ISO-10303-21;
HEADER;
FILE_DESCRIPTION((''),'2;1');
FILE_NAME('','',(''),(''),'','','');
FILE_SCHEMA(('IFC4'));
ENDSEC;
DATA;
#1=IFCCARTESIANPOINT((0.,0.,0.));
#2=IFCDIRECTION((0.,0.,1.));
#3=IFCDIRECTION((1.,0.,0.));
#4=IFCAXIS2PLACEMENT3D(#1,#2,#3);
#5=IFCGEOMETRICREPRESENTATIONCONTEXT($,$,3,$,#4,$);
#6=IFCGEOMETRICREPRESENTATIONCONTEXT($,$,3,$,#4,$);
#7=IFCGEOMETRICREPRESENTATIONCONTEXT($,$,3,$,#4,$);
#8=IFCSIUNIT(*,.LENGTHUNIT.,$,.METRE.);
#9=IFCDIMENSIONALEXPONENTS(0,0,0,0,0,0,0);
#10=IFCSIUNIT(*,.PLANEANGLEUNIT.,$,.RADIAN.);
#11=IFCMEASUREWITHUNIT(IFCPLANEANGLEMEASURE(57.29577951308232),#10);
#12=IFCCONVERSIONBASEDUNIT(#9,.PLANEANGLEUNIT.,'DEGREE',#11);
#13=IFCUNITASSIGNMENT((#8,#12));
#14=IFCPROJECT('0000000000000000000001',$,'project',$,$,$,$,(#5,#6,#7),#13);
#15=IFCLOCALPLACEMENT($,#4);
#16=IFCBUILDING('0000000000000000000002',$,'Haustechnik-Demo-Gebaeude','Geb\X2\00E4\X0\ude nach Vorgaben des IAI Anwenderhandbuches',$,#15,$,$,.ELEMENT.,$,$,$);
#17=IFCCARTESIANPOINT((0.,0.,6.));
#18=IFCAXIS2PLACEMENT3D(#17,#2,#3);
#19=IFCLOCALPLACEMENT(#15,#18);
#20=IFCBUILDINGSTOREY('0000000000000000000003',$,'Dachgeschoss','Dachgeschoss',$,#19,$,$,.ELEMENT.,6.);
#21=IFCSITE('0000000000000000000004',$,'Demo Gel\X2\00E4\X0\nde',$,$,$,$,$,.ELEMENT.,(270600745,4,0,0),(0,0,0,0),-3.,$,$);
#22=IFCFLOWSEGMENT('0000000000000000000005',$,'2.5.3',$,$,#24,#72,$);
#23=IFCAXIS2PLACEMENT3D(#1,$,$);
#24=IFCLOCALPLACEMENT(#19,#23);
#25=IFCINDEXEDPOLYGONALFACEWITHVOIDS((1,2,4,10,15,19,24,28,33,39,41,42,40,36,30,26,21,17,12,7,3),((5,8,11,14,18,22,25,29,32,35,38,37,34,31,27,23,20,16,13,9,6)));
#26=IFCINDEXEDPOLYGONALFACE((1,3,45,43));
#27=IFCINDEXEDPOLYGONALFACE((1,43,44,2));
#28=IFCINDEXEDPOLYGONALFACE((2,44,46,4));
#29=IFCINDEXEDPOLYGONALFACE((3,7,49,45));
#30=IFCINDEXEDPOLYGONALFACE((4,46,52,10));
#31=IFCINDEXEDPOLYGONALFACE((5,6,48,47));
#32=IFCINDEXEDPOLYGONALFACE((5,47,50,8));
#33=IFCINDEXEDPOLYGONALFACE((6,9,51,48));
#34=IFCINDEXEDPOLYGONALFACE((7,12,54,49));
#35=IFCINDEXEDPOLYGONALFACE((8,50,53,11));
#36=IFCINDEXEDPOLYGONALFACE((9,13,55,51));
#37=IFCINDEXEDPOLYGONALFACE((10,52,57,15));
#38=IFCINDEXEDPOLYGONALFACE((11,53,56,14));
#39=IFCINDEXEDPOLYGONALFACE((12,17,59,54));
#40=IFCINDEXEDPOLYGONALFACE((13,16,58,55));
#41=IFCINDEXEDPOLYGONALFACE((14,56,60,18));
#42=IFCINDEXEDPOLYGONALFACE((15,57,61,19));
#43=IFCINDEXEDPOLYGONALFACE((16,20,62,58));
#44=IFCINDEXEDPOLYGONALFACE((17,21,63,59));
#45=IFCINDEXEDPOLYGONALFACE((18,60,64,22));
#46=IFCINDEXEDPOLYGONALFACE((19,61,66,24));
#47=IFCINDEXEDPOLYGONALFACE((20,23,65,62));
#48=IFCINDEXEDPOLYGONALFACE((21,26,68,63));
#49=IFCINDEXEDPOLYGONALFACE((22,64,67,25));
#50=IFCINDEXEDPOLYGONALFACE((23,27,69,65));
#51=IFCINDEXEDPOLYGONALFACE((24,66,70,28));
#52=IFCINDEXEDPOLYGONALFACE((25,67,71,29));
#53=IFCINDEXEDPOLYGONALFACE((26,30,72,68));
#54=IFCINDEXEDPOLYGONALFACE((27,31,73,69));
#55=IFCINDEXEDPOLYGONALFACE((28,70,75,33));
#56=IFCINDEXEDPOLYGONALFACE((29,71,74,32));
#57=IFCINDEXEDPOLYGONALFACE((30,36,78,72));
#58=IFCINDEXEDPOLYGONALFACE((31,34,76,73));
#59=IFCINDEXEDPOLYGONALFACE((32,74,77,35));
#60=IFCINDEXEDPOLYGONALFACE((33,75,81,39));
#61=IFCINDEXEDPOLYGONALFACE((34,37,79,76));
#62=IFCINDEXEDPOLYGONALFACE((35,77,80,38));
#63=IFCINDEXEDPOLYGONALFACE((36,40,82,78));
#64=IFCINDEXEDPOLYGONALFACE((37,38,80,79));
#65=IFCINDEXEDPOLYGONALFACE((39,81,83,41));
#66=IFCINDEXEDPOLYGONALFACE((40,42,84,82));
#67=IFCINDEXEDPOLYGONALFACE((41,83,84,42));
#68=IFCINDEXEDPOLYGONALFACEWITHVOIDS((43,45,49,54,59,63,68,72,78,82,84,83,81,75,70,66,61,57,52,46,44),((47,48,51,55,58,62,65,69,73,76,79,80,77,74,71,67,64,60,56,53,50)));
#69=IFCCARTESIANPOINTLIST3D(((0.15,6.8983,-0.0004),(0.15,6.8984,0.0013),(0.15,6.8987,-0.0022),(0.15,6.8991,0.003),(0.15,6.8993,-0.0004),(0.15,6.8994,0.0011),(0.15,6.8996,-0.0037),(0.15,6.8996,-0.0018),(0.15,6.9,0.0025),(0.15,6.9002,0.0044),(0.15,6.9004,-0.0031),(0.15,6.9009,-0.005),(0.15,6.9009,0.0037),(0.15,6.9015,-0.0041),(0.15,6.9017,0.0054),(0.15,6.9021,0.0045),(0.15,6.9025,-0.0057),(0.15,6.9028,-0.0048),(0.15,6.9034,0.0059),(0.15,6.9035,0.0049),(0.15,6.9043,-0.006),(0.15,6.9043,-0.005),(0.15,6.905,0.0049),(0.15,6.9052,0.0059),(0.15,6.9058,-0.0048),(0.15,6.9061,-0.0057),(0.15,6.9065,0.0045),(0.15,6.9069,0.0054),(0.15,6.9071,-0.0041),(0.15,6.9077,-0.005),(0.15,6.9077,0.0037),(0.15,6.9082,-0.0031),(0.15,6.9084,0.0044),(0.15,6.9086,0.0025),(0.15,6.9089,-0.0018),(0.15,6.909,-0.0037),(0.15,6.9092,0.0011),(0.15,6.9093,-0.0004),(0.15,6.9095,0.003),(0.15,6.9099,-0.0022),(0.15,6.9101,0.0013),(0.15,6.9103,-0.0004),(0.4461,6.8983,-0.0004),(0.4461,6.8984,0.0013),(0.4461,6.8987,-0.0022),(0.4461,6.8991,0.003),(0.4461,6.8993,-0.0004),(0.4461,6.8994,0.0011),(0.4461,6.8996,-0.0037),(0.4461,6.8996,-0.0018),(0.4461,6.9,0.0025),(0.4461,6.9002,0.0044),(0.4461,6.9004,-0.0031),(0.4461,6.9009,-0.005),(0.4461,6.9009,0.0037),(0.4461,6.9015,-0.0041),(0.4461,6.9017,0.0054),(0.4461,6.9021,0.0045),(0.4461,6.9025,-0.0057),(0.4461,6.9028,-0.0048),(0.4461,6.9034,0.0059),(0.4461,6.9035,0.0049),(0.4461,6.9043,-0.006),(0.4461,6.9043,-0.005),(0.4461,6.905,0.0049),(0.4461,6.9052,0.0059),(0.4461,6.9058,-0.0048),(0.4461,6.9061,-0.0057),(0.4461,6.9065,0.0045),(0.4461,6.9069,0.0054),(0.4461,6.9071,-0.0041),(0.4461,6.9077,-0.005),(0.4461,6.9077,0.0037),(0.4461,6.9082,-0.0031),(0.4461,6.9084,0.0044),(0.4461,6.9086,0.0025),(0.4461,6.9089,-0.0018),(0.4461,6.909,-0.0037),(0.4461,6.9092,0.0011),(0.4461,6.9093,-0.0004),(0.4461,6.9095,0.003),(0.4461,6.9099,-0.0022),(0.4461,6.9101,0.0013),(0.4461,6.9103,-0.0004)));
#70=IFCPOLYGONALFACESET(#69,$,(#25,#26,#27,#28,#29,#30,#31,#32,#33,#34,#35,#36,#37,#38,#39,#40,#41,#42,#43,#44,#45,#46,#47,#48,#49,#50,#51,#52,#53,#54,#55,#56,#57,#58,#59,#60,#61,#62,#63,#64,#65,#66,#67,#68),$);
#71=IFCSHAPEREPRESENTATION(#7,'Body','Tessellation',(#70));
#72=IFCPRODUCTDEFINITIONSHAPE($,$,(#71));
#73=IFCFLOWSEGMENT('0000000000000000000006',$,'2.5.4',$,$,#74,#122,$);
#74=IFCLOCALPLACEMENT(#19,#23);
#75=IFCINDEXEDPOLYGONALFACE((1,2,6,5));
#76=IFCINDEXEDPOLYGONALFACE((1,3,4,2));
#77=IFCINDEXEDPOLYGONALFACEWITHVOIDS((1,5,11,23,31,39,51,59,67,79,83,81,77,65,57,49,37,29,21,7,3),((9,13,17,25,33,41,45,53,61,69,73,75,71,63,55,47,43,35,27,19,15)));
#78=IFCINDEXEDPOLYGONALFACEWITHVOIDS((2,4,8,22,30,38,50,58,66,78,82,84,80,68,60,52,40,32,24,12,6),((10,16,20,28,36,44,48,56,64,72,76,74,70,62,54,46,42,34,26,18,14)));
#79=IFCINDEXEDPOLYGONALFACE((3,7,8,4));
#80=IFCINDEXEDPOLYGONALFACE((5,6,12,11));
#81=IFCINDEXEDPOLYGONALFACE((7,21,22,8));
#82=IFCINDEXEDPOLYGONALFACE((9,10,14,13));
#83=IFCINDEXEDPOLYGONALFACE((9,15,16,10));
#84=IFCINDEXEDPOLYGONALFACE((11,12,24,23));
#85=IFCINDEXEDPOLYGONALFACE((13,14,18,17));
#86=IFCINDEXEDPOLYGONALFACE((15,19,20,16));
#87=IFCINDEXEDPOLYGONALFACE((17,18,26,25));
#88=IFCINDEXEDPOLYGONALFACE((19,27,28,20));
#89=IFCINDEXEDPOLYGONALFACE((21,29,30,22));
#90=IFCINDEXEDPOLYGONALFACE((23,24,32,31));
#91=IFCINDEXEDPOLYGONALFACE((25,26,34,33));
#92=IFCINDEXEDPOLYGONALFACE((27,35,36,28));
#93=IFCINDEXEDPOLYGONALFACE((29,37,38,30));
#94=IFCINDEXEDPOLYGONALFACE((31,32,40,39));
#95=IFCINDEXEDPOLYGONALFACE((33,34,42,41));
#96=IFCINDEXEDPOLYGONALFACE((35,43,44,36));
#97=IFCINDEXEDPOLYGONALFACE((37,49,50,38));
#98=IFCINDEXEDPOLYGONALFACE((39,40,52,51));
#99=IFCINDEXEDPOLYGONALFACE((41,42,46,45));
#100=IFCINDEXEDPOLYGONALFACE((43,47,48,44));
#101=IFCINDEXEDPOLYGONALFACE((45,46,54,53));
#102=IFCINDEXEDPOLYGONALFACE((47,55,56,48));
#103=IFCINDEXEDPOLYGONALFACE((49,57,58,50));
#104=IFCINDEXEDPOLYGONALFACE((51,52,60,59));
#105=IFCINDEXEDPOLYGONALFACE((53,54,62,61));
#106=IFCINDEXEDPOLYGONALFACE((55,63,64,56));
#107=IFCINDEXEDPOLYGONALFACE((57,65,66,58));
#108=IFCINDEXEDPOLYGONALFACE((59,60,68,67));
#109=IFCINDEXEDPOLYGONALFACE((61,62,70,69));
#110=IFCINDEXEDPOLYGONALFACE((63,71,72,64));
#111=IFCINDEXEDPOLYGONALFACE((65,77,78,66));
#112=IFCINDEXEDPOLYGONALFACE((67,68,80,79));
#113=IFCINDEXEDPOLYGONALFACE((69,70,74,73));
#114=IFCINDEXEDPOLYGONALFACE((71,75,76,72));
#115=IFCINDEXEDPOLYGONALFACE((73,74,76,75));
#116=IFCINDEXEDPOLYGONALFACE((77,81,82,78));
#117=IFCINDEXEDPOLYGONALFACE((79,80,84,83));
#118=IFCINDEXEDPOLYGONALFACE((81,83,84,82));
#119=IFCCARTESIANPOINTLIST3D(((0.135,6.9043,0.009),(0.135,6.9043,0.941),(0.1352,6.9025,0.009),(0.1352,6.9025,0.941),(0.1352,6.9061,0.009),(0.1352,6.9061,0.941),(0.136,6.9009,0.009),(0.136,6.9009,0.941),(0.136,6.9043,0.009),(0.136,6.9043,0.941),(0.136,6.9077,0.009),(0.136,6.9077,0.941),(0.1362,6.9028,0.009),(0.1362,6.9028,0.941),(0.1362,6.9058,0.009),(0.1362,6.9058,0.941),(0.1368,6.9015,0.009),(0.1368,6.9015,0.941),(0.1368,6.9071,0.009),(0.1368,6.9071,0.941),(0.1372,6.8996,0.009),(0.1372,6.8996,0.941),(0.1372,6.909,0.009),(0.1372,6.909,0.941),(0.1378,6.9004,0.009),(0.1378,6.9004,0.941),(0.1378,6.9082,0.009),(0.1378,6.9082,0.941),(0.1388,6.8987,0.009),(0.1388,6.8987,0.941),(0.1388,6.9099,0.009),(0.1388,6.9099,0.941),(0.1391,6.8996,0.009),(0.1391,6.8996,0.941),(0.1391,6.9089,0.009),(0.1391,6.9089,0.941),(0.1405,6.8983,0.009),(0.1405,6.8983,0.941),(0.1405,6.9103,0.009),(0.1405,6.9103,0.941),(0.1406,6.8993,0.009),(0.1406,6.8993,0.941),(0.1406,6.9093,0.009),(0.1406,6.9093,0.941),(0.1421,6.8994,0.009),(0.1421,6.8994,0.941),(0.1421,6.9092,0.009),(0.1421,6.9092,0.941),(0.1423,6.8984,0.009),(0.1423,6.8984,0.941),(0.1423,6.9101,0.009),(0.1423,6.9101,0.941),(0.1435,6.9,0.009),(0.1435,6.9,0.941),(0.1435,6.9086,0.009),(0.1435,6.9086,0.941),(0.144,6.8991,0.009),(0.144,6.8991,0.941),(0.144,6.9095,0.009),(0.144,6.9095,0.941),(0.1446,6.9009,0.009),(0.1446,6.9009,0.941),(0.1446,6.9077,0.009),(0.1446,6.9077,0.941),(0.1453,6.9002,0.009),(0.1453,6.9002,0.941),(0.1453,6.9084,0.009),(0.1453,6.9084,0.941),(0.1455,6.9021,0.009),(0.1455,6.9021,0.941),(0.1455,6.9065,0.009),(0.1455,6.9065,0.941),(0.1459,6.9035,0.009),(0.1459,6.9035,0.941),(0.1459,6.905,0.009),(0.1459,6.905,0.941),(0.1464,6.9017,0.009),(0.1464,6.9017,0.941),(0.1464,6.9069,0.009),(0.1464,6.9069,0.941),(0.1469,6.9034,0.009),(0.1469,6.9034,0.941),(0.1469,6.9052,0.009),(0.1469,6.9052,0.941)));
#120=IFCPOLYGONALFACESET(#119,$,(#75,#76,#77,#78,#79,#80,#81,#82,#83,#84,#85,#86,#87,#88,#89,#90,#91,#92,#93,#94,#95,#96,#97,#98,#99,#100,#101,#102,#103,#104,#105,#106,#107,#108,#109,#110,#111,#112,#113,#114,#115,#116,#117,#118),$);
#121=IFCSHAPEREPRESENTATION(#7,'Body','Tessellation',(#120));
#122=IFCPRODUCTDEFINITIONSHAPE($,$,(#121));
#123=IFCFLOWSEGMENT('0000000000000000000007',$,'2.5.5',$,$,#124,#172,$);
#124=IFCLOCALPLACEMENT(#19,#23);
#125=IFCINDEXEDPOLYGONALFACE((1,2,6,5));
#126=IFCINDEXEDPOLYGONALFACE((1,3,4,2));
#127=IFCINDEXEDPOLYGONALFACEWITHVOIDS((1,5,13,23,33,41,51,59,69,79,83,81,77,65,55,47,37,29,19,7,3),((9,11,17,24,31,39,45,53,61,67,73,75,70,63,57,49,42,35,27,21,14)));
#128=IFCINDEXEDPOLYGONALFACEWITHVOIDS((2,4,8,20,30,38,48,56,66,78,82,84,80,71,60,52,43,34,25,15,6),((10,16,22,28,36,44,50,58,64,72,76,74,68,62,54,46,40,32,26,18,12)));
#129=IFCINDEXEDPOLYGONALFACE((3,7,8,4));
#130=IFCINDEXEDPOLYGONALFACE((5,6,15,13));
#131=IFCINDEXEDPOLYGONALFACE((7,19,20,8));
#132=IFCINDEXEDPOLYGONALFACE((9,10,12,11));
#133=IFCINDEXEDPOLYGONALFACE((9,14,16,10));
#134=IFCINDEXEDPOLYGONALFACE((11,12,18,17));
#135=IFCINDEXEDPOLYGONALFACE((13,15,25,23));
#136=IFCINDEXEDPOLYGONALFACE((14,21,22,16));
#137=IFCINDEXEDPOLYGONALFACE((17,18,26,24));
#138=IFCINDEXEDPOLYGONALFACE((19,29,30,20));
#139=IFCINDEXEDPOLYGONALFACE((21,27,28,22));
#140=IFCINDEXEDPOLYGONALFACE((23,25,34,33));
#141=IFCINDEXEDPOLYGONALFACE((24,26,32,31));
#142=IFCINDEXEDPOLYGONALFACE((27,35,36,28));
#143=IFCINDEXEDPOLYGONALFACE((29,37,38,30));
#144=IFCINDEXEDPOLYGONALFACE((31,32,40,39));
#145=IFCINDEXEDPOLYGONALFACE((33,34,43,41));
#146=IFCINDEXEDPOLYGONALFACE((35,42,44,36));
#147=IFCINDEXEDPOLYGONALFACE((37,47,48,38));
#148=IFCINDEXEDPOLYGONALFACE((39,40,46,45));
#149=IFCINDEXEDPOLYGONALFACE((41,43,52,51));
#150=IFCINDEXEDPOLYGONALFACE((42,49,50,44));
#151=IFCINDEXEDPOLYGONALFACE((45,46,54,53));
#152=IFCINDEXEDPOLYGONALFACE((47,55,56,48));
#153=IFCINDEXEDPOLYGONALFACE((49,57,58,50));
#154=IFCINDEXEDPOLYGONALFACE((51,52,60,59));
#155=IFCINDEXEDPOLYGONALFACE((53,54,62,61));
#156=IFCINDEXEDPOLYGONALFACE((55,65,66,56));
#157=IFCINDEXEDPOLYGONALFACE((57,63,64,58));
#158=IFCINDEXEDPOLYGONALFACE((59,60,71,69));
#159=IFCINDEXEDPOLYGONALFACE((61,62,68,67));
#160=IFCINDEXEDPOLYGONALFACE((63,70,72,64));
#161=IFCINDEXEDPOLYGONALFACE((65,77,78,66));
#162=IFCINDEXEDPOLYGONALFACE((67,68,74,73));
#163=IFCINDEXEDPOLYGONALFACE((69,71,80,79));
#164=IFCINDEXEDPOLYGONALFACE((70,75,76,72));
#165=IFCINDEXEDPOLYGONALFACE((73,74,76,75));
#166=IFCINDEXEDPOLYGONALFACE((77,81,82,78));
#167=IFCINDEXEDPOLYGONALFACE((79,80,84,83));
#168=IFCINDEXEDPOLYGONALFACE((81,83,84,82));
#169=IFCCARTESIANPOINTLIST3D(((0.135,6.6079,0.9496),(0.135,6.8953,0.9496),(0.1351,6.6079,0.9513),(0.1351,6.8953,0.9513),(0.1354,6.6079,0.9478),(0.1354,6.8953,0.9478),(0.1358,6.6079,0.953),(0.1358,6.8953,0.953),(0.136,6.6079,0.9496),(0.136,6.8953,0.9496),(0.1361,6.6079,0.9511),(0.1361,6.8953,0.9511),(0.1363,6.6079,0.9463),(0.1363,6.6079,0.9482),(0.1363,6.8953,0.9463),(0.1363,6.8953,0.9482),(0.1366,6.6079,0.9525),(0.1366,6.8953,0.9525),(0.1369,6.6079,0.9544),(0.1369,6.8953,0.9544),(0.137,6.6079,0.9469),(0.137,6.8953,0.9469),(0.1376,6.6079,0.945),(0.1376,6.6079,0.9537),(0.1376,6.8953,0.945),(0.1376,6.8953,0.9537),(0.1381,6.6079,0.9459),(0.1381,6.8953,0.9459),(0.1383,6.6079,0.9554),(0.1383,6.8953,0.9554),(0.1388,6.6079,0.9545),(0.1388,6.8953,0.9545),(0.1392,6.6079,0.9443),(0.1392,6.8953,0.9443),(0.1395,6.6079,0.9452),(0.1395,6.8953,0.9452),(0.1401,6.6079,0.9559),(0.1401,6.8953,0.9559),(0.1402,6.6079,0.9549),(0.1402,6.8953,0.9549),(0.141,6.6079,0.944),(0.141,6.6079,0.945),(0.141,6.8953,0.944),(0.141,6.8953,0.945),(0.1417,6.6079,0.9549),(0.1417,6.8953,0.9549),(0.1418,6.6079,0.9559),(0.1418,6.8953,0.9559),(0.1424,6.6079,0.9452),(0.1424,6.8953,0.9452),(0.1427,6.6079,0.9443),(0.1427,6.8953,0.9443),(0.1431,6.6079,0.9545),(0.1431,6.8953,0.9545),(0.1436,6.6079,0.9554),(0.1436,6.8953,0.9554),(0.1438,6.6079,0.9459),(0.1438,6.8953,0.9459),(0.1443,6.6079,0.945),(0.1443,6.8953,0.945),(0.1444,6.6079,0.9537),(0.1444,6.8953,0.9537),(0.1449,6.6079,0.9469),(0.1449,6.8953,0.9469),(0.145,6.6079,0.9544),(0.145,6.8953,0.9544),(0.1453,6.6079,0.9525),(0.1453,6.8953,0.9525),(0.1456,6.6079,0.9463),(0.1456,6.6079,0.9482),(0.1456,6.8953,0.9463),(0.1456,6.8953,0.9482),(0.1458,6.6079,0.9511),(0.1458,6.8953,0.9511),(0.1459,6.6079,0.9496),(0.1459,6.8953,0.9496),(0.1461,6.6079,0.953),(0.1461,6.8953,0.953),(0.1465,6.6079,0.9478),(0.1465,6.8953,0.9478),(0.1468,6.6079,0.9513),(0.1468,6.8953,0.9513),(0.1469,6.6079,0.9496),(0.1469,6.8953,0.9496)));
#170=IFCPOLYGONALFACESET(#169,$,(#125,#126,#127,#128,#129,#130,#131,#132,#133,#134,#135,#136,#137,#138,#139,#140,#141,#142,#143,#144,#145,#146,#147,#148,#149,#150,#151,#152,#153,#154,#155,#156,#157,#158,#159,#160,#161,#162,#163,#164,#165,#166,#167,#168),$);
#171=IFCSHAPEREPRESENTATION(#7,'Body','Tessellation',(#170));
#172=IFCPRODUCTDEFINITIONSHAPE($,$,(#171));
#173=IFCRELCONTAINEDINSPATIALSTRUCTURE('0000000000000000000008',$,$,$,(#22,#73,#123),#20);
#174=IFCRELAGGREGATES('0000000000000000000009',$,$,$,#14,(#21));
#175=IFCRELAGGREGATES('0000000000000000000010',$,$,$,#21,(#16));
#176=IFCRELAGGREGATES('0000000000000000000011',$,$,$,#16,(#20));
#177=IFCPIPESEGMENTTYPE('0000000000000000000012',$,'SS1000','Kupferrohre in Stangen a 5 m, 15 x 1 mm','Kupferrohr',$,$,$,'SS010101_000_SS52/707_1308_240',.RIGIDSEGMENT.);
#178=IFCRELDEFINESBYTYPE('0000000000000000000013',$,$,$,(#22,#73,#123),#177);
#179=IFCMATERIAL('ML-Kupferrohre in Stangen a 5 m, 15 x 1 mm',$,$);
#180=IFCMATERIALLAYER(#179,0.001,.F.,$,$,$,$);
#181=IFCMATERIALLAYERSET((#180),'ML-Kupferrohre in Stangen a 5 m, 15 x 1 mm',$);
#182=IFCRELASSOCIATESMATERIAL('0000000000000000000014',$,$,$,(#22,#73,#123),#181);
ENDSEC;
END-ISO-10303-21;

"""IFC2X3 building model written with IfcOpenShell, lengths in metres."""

from ifc_helpers import new_model, entity, si_unit, converted_unit, frame, origin_with_axes, origin_2d_with_axis, place, context, project, spatial, hollow_circle, extrude, material, layer, layer_set, layer_usage, type_object, element, save


model = new_model("IFC2X3")

# Units and contexts
context_of_model_1 = context(None, 3, world=origin_with_axes())
context_of_model_2 = context(None, 3, world=origin_with_axes())
context_of_model_3 = context(None, 3, world=origin_with_axes())
ifc_project = project(units=[si_unit("LENGTHUNIT", "METRE"), converted_unit("PLANEANGLEUNIT", "DEGREE", entity("IfcPlaneAngleMeasure", 57.29577951308232), si_unit("PLANEANGLEUNIT", "RADIAN"), dimensions=[0, 0, 0, 0, 0, 0, 0])], contexts=[context_of_model_1, context_of_model_2, context_of_model_3])

# Site, building, storey
site = spatial("IfcSite", under=ifc_project, Name="Demo Gelände", CompositionType="ELEMENT", RefLatitude=(270600745, 4, 0, 0), RefLongitude=(0, 0, 0, 0), RefElevation=-3.0)
building_placement = place(None, origin_with_axes())
building = spatial("IfcBuilding", under=site, at=building_placement, Name="Haustechnik-Demo-Gebaeude", Description="Gebäude nach Vorgaben des IAI Anwenderhandbuches", CompositionType="ELEMENT")
storey_placement = place(building_placement, frame((0.0, 0.0, 6.0), z_axis=(0.0, 0.0, 1.0), x_axis=(1.0, 0.0, 0.0)))
storey = spatial("IfcBuildingStorey", under=building, at=storey_placement, Name="Dachgeschoss", Description="Dachgeschoss", CompositionType="ELEMENT", Elevation=6.0)

# Flow segments
ifc_material = material(Name="ML-Kupferrohre in Stangen a 5 m, 15 x 1 mm")
ifc_layer = layer(ifc_material, 0.001, ventilated=False)
ifc_layer_set = layer_set([ifc_layer], Name="ML-Kupferrohre in Stangen a 5 m, 15 x 1 mm")
ifc_layer_usage = layer_usage(ifc_layer_set, "AXIS2", "POSITIVE", 0.0)
pipe_segment_type_1 = type_object("IfcPipeSegmentType", Name="SS1000", Description="Kupferrohre in Stangen a 5 m, 15 x 1 mm", ApplicableOccurrence="Kupferrohr", ElementType="SS010101_000_SS52/707_1308_240", PredefinedType="RIGIDSEGMENT")
flow_segment_1_placement = place(storey_placement, frame((0.4461, 6.9043, 0.0), z_axis=(-1.0, 0.0, 0.0), x_axis=(0.0, 0.0, -1.0)))
element("IfcFlowSegment", 1, at=flow_segment_1_placement, inside=storey, type_object=pipe_segment_type_1, material=ifc_layer_usage, Name="2.5.3", context=context_of_model_3, shape_type="SweptSolid", body=[
    extrude(hollow_circle(Radius=0.006, WallThickness=0.001, at=origin_2d_with_axis()), origin_with_axes(), (0.0, 0.0, 1.0), 0.2962),
])
flow_segment_2_placement = place(storey_placement, frame((0.141, 6.9043, 0.009), z_axis=(0.0, 0.0, 1.0), x_axis=(-1.0, 0.0, 0.0)))
element("IfcFlowSegment", 2, at=flow_segment_2_placement, inside=storey, type_object=pipe_segment_type_1, material=ifc_layer_usage, Name="2.5.4", context=context_of_model_3, shape_type="SweptSolid", body=[
    extrude(hollow_circle(Radius=0.006, WallThickness=0.001, at=origin_2d_with_axis()), origin_with_axes(), (0.0, 0.0, 1.0), 0.932),
])
flow_segment_3_placement = place(storey_placement, frame((0.141, 6.8953, 0.95), z_axis=(0.0, -1.0, 0.0), x_axis=(0.0, 0.0, -1.0)))
element("IfcFlowSegment", 3, at=flow_segment_3_placement, inside=storey, type_object=pipe_segment_type_1, material=ifc_layer_usage, Name="2.5.5", context=context_of_model_3, shape_type="SweptSolid", body=[
    extrude(hollow_circle(Radius=0.006, WallThickness=0.001, at=origin_2d_with_axis()), origin_with_axes(), (0.0, 0.0, 1.0), 0.2874),
])

save(model, "model.ifc")
